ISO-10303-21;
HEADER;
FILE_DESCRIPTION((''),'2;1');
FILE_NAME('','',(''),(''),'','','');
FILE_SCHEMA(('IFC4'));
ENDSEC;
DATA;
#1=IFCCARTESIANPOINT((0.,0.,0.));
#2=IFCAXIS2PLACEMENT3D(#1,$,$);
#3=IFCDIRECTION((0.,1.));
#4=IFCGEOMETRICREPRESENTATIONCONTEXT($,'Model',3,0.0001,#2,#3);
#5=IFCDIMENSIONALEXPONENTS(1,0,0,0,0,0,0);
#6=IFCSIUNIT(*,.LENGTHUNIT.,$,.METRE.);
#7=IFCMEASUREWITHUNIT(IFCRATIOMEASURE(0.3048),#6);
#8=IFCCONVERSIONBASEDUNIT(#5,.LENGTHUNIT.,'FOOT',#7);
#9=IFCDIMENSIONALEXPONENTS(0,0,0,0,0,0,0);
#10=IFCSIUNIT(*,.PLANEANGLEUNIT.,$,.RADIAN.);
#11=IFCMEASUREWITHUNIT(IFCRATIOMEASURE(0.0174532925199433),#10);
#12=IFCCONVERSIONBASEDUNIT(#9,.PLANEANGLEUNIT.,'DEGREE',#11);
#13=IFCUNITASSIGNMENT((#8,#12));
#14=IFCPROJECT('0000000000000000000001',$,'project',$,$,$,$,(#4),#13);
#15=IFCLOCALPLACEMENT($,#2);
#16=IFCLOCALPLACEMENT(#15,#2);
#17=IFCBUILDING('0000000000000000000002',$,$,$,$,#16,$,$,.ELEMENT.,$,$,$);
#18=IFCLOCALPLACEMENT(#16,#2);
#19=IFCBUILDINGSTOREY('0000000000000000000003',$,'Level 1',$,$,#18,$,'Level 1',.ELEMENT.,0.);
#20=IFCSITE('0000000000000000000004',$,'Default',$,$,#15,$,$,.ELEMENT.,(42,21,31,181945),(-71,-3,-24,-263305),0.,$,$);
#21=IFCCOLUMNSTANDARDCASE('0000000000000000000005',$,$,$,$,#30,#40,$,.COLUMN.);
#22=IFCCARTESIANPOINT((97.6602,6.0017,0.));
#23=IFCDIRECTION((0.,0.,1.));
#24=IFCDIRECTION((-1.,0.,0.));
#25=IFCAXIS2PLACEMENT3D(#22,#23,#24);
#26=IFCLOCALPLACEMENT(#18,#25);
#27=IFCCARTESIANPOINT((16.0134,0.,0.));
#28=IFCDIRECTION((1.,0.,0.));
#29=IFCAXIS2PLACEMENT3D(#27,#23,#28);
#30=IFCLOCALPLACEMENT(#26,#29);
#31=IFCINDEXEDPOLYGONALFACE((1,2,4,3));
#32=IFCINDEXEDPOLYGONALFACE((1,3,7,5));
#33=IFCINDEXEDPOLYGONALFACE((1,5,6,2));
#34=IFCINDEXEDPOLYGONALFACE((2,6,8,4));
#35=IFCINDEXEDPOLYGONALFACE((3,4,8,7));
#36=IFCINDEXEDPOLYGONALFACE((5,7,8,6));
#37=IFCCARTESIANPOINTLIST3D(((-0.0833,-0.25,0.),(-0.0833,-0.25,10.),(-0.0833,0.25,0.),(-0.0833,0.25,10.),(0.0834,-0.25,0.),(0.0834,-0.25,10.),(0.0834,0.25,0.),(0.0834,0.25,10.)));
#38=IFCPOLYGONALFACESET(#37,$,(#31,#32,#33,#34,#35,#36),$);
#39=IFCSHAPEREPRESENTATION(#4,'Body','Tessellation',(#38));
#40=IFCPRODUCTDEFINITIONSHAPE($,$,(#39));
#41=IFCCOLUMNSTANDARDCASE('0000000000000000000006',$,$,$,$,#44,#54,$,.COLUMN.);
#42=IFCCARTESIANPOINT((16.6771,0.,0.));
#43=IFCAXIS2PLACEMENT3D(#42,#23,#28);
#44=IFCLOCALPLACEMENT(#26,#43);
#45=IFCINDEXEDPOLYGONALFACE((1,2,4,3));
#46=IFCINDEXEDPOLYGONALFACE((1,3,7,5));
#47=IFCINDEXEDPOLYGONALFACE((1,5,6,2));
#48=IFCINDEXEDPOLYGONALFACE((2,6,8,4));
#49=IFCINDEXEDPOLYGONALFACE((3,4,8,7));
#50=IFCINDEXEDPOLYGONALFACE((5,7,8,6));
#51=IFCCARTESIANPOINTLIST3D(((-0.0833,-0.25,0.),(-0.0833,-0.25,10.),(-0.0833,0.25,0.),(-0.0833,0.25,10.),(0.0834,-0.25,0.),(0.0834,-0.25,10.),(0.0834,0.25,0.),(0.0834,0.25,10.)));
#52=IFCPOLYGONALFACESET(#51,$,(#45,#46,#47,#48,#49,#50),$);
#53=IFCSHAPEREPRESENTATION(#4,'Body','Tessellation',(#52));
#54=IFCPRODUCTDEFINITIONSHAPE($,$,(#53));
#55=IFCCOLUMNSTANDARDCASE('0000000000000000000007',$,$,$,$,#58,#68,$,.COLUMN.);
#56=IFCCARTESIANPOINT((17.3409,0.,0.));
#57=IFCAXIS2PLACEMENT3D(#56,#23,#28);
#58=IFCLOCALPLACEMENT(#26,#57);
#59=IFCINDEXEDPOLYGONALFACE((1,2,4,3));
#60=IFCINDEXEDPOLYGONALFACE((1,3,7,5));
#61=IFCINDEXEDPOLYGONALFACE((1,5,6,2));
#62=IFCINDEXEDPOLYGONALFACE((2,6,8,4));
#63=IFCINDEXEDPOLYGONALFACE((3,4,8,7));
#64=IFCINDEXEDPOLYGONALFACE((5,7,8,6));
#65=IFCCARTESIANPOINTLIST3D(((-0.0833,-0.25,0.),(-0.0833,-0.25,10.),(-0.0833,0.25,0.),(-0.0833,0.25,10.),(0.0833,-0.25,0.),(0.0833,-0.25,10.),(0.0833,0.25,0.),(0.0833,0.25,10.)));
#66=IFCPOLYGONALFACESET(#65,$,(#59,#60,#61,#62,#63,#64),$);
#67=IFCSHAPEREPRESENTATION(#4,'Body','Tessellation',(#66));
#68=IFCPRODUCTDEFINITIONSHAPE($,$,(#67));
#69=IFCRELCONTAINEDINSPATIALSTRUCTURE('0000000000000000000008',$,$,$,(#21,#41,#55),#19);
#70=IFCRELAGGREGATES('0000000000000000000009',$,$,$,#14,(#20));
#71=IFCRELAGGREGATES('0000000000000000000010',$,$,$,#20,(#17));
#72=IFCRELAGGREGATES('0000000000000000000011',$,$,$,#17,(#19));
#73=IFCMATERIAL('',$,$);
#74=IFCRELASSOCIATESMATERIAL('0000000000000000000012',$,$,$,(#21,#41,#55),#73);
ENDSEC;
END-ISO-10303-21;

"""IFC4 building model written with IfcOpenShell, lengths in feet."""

from ifc_helpers import new_model, entity, si_unit, converted_unit, direction, frame, origin, place, context, project, spatial, rectangle, extrude, material, element, save


model = new_model("IFC4")

# Units and contexts
model_context = context("Model", 3, precision=0.0001, world=origin(), true_north=direction((0.0, 1.0)))
ifc_project = project(units=[converted_unit("LENGTHUNIT", "FOOT", entity("IfcRatioMeasure", 0.3048), si_unit("LENGTHUNIT", "METRE"), dimensions=[1, 0, 0, 0, 0, 0, 0]), converted_unit("PLANEANGLEUNIT", "DEGREE", entity("IfcRatioMeasure", 0.0174532925199433), si_unit("PLANEANGLEUNIT", "RADIAN"), dimensions=[0, 0, 0, 0, 0, 0, 0])], contexts=[model_context])

# Site, building, storey
site_placement = place(None, origin())
site = spatial("IfcSite", under=ifc_project, at=site_placement, Name="Default", CompositionType="ELEMENT", RefLatitude=(42, 21, 31, 181945), RefLongitude=(-71, -3, -24, -263305), RefElevation=0.0)
building_placement = place(site_placement, origin())
building = spatial("IfcBuilding", under=site, at=building_placement, CompositionType="ELEMENT")
storey_placement = place(building_placement, origin())
storey = spatial("IfcBuildingStorey", under=building, at=storey_placement, Name="Level 1", LongName="Level 1", CompositionType="ELEMENT", Elevation=0.0)

# Columns
ifc_material_1 = material(Name="")
placement = place(storey_placement, frame((97.6602, 6.0017, 0.0), z_axis=(0.0, 0.0, 1.0), x_axis=(-1.0, 0.0, 0.0)))
for number, where, z_axis, x_axis in (
    (1, (16.0134, 0.0, 0.0), (0.0, 0.0, 1.0), (1.0, 0.0, 0.0)),
    (2, (16.6771, 0.0, 0.0), (0.0, 0.0, 1.0), (1.0, 0.0, 0.0)),
    (3, (17.3409, 0.0, 0.0), (0.0, 0.0, 1.0), (1.0, 0.0, 0.0)),
):
    element("IfcColumnStandardCase", number, at=place(placement, frame(where, z_axis=z_axis, x_axis=x_axis)), inside=storey, material=ifc_material_1, PredefinedType="COLUMN", context=model_context, shape_type="SweptSolid", body=[
        extrude(rectangle(XDim=0.1667, YDim=0.5), origin(), (0.0, 0.0, 1.0), 10.0),
    ])

save(model, "model.ifc")
